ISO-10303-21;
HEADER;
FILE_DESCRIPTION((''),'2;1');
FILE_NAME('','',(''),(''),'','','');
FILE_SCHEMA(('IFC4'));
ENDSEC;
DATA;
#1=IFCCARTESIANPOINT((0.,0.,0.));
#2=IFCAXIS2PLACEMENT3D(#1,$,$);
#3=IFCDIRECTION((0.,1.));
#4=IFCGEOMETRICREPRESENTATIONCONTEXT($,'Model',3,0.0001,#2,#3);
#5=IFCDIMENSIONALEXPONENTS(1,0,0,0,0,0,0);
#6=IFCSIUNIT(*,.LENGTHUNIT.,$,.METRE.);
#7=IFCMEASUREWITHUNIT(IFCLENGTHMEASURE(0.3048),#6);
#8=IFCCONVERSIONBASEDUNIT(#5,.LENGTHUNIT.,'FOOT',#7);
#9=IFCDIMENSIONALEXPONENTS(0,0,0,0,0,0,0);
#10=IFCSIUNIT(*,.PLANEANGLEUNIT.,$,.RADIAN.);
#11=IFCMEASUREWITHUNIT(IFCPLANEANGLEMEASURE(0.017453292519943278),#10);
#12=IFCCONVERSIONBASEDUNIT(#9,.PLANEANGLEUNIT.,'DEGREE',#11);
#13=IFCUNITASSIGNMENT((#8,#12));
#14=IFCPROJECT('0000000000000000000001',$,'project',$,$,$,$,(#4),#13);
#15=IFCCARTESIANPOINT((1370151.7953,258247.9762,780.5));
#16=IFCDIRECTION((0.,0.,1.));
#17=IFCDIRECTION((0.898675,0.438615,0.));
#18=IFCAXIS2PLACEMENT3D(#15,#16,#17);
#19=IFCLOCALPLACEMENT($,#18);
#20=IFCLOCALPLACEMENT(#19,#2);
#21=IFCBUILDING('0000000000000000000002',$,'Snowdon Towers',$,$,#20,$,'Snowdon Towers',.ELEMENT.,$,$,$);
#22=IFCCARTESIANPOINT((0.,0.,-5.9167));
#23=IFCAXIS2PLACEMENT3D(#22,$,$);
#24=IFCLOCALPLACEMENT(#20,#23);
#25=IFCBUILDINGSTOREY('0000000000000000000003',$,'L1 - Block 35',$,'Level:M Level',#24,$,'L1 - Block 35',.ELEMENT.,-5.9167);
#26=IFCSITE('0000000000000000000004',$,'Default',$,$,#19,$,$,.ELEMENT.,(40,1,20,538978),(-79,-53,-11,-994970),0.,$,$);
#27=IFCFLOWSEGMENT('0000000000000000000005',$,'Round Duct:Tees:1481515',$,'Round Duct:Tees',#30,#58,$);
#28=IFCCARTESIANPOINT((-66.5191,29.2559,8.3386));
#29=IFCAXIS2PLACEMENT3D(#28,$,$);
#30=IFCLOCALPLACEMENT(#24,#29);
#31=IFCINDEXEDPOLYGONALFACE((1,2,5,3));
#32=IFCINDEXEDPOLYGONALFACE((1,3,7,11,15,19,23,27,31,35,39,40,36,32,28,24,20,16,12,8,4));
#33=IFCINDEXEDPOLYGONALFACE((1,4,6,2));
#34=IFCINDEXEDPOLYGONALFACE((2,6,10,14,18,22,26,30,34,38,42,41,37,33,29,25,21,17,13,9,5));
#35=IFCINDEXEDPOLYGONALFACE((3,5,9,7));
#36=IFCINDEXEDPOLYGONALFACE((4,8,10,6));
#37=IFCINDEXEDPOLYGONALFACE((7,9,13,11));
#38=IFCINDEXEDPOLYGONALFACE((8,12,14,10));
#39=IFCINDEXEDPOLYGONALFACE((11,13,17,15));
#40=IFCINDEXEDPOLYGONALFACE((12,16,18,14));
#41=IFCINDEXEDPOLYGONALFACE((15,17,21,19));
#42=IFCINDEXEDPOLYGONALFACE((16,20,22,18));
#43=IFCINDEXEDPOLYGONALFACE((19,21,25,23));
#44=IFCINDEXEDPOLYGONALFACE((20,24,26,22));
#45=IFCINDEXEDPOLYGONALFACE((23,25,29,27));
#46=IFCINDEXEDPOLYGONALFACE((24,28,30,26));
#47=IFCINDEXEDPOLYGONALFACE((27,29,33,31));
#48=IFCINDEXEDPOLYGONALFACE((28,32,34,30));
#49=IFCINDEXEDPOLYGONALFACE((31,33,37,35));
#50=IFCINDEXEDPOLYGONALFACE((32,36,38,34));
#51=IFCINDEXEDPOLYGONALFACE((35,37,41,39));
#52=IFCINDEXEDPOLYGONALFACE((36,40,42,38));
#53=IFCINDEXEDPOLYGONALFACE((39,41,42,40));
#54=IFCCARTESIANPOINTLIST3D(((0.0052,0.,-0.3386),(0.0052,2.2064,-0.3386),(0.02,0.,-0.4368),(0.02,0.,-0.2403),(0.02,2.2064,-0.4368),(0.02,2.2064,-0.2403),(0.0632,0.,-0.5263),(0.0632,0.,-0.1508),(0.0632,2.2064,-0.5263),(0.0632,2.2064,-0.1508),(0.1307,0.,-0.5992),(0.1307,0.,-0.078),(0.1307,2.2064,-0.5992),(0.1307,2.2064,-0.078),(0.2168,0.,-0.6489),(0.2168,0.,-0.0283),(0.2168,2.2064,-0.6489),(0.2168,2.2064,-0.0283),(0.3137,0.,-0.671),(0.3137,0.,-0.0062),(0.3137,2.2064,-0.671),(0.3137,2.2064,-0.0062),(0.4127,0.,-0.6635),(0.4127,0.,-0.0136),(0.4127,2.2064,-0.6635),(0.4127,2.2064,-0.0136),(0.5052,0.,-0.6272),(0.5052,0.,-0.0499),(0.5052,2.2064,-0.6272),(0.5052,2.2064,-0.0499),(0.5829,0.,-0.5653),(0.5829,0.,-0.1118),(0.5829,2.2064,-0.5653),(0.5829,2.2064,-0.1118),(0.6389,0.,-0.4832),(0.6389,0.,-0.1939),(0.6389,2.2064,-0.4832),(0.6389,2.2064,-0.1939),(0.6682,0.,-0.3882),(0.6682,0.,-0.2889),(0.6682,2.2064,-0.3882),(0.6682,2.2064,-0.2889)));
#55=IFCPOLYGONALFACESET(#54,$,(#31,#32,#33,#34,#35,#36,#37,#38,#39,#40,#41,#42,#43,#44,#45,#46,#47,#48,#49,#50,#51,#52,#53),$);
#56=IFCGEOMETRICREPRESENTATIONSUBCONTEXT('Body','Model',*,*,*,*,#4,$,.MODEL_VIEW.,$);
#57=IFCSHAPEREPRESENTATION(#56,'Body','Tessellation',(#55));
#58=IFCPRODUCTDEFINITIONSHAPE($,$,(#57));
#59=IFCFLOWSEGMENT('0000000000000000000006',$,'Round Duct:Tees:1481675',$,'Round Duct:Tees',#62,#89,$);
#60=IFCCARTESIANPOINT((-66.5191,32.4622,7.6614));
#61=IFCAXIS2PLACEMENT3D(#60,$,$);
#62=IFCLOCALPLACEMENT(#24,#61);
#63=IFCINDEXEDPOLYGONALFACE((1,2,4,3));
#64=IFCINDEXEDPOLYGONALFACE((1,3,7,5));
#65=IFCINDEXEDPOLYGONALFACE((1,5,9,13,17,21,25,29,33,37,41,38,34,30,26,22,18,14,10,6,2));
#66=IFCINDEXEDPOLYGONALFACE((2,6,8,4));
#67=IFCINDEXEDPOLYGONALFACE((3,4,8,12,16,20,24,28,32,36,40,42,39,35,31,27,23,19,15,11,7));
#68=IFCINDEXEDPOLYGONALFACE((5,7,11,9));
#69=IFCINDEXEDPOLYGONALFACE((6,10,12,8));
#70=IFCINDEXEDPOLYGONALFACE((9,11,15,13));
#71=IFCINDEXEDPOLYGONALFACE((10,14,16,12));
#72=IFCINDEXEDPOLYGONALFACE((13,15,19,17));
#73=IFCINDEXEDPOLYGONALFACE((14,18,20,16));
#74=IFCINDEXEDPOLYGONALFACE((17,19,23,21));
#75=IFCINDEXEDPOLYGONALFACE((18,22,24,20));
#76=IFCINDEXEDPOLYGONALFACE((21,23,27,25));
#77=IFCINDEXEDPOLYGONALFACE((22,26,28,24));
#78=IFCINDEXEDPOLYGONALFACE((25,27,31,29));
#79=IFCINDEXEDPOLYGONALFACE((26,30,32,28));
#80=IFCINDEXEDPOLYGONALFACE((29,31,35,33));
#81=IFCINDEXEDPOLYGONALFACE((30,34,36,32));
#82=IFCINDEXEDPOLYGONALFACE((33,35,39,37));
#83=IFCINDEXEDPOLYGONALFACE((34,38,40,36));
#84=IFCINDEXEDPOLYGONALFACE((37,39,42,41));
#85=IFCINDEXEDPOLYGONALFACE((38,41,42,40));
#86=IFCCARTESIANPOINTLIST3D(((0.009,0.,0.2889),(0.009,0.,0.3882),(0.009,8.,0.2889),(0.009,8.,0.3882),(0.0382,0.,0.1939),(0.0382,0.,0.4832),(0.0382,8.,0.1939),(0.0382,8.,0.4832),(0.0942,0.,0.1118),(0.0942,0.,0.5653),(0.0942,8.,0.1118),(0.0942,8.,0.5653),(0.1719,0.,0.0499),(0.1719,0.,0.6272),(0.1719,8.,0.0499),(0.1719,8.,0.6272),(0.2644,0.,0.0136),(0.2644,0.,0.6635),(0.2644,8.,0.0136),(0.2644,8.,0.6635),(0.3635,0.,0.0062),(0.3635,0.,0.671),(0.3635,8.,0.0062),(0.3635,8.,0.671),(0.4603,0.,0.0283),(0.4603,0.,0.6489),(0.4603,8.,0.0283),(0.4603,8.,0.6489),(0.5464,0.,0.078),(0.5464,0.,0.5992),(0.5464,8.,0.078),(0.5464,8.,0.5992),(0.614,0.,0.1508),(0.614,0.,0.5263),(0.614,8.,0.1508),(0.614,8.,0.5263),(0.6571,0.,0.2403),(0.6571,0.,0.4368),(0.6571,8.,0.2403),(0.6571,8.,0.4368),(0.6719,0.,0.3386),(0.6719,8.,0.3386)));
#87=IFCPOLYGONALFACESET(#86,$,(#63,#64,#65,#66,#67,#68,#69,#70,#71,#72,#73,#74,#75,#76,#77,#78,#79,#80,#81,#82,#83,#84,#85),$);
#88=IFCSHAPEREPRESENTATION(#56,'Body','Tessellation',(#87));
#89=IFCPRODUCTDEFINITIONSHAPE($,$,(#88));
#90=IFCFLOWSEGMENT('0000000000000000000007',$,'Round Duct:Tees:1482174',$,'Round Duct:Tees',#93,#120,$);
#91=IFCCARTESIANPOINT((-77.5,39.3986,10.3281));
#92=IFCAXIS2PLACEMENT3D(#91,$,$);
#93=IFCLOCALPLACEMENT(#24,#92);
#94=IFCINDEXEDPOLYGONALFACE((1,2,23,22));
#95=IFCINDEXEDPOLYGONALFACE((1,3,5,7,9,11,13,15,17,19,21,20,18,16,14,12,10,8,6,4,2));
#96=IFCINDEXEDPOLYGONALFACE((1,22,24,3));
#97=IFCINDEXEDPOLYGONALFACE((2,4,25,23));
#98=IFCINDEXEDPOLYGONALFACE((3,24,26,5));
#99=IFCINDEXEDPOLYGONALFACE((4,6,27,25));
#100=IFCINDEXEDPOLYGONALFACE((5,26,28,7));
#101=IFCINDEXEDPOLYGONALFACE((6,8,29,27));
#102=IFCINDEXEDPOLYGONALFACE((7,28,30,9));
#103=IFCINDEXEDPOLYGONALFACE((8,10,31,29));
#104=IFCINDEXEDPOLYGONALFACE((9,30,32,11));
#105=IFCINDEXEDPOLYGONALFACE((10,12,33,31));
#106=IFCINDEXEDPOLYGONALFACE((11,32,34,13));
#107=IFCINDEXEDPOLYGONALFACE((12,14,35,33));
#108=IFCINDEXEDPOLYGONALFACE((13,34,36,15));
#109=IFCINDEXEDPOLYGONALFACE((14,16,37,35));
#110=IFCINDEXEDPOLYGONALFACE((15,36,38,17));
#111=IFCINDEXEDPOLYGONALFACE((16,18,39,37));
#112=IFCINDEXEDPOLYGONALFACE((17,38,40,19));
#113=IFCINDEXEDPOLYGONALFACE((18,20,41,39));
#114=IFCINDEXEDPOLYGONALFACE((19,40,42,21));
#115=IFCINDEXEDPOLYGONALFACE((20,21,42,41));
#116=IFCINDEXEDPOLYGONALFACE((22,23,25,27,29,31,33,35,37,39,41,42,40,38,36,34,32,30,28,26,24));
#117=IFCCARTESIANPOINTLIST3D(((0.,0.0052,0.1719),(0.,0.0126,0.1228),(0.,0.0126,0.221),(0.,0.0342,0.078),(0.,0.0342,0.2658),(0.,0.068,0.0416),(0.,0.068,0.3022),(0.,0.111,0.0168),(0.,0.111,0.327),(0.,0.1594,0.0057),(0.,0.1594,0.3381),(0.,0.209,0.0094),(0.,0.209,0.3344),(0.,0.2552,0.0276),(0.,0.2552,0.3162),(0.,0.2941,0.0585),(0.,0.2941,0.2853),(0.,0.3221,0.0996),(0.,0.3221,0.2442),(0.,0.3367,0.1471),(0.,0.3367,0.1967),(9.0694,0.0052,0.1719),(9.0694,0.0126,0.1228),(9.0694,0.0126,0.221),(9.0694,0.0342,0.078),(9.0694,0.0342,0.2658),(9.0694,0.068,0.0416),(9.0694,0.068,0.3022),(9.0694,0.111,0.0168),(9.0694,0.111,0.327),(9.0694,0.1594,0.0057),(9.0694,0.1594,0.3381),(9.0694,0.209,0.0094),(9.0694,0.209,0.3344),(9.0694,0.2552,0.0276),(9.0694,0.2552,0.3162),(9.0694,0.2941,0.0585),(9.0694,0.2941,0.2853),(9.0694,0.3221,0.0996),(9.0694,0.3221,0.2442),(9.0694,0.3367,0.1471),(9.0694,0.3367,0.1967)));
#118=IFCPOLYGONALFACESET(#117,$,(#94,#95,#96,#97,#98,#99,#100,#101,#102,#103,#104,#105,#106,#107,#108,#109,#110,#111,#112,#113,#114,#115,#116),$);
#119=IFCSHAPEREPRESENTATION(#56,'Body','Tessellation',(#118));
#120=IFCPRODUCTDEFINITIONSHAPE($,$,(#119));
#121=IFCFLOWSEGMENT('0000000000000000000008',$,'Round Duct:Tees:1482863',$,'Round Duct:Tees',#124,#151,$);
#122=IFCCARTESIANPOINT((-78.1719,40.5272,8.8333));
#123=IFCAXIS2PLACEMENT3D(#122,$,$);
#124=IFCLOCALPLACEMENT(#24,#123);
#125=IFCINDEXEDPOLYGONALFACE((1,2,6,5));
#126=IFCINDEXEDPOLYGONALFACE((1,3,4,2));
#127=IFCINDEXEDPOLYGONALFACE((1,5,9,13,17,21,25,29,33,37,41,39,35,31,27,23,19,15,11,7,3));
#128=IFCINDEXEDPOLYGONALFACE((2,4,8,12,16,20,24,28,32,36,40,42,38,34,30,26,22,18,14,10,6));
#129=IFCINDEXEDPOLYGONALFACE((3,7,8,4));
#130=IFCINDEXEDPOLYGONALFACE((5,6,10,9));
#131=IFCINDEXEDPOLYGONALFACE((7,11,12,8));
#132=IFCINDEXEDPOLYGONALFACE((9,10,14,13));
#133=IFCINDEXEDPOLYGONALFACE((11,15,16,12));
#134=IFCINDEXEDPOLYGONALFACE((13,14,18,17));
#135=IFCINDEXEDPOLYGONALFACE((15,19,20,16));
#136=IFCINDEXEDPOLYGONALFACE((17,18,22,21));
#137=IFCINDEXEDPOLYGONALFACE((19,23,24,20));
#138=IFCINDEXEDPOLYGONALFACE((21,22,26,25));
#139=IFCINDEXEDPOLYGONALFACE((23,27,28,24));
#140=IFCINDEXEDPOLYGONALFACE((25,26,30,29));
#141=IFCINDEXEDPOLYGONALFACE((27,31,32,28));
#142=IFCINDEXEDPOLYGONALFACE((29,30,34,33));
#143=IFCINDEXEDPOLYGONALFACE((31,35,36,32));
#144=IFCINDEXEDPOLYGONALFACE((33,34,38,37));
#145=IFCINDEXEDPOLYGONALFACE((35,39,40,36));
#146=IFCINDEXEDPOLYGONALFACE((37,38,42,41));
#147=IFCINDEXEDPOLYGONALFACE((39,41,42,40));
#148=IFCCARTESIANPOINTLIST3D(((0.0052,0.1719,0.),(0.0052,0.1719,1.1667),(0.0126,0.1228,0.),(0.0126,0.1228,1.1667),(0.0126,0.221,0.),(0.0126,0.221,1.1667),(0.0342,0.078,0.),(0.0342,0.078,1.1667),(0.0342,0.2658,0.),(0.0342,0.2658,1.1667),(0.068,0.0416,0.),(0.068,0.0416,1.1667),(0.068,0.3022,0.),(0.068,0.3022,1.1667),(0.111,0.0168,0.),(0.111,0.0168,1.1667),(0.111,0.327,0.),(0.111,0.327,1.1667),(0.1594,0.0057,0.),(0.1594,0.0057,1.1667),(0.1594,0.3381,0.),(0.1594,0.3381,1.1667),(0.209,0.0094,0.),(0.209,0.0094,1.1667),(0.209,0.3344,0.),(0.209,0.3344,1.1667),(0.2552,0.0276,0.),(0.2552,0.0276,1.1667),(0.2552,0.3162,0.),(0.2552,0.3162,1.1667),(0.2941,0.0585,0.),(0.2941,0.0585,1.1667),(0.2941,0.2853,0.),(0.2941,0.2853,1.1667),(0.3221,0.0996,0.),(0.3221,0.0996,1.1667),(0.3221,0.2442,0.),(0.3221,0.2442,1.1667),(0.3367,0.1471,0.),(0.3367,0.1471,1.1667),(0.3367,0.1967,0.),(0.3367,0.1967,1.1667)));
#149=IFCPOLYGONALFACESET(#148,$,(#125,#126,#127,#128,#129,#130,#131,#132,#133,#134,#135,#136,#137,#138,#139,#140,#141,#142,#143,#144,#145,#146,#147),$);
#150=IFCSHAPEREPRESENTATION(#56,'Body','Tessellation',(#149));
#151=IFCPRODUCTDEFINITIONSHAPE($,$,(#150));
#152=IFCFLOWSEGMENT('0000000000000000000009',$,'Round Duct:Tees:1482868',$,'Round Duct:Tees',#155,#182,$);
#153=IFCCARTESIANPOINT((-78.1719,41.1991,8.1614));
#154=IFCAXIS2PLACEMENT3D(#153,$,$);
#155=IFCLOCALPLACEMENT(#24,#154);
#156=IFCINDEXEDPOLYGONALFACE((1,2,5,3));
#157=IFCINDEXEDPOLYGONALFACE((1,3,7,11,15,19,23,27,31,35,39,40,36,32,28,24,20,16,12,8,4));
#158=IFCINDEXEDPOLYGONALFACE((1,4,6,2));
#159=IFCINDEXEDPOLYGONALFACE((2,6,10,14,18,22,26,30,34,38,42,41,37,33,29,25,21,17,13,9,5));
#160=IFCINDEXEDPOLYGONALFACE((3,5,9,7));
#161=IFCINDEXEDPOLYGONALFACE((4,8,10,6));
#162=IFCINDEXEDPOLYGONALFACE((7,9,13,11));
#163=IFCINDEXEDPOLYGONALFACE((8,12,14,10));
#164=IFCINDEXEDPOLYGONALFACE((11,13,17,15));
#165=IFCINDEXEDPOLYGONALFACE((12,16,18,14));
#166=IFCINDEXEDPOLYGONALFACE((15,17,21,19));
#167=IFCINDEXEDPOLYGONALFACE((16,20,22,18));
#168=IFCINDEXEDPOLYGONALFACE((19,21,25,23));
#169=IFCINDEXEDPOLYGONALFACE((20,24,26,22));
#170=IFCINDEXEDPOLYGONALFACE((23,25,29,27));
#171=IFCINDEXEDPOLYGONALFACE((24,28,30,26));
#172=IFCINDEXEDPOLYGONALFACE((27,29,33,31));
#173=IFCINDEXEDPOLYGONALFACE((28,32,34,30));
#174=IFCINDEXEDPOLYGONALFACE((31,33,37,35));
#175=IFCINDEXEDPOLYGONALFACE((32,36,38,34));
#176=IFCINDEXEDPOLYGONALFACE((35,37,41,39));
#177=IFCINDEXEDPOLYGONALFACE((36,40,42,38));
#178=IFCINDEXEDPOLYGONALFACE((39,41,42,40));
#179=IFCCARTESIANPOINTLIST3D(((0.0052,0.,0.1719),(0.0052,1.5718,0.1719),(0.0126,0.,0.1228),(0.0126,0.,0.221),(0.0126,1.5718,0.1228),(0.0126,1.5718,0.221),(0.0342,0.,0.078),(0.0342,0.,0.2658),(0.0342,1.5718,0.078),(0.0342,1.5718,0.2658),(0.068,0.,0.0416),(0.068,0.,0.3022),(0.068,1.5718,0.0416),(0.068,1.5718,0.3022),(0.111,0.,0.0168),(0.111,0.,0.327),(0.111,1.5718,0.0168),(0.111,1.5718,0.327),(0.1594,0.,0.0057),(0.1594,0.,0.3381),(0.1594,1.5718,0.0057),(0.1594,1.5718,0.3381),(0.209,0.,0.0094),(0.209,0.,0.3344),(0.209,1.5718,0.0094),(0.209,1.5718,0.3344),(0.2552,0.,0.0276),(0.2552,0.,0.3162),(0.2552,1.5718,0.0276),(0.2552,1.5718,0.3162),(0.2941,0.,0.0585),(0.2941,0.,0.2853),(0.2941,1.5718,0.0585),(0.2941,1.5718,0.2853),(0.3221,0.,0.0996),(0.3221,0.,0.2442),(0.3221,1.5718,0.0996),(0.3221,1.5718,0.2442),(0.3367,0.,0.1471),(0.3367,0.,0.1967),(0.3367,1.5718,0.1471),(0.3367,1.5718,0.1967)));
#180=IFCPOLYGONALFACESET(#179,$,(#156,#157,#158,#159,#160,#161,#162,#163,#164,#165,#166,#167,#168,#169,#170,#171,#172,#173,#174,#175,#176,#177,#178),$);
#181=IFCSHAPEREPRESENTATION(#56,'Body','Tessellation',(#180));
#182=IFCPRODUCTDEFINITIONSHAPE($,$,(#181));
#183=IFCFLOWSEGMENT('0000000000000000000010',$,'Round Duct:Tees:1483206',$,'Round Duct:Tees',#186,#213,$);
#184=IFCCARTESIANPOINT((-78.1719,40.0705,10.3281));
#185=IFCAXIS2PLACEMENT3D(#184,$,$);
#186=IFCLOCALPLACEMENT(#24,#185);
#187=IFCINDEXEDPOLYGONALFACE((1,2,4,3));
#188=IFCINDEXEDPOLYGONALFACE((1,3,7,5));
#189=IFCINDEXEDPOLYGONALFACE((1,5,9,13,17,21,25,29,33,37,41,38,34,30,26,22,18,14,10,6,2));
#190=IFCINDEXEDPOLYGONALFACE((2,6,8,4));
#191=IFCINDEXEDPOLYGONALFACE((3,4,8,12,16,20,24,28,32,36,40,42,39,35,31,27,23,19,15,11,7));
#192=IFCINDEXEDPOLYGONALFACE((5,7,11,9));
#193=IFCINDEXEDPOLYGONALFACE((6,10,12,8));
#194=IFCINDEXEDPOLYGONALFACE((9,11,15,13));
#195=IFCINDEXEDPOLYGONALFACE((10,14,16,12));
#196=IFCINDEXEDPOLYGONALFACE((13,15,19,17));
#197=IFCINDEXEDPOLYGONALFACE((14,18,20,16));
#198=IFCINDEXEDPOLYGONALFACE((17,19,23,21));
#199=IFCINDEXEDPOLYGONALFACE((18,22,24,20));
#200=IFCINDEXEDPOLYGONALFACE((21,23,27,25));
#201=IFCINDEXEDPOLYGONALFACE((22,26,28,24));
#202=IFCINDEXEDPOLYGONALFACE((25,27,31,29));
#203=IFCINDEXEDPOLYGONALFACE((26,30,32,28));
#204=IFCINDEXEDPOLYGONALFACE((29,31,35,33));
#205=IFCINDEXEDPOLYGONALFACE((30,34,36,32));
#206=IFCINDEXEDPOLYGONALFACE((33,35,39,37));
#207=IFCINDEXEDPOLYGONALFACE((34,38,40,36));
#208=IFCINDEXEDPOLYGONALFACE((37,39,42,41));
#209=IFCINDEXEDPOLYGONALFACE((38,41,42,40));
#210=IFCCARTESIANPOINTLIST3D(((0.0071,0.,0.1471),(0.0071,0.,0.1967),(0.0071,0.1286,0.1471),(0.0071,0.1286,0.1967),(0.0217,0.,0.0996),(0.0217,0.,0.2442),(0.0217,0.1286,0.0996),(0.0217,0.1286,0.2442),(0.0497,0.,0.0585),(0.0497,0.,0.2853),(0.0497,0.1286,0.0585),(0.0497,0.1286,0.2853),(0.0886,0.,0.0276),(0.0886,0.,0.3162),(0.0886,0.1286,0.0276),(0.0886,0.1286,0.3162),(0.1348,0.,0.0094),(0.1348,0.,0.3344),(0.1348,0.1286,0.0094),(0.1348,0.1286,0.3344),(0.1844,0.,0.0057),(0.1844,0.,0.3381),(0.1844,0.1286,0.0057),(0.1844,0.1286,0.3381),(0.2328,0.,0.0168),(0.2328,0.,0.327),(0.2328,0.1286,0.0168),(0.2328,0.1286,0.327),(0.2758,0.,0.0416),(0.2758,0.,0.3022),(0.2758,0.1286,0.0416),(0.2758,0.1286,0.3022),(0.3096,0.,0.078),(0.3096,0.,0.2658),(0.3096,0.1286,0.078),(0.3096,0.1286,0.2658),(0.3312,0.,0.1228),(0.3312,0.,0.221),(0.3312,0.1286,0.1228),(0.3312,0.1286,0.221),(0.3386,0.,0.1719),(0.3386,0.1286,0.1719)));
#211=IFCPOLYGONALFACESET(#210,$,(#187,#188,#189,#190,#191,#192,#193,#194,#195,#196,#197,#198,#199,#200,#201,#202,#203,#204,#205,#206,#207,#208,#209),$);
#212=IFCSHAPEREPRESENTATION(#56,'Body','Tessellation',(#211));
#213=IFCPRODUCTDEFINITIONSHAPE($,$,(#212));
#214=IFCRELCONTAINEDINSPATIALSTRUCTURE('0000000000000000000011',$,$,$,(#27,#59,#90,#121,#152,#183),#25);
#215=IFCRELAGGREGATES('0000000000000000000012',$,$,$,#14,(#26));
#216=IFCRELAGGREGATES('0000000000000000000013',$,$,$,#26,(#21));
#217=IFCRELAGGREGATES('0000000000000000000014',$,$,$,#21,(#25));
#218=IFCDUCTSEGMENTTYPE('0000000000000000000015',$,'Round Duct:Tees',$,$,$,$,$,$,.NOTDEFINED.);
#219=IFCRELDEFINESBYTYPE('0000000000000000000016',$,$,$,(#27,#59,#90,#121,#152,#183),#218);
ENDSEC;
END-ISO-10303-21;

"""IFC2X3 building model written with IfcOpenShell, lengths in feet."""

from ifc_helpers import new_model, entity, si_unit, converted_unit, direction, frame, frame_2d, origin, origin_2d_with_axis, place, context, subcontext, project, spatial, circle, extrude, type_object, element, save


model = new_model("IFC2X3")

# Units and contexts
model_context = context("Model", 3, precision=0.0001, world=origin(), true_north=direction((0.0, 1.0)))
body_context = subcontext(model_context, "Body", "Model", "MODEL_VIEW")
ifc_project = project(units=[converted_unit("LENGTHUNIT", "FOOT", entity("IfcLengthMeasure", 0.3048), si_unit("LENGTHUNIT", "METRE"), dimensions=[1, 0, 0, 0, 0, 0, 0]), converted_unit("PLANEANGLEUNIT", "DEGREE", entity("IfcPlaneAngleMeasure", 0.017453292519943278), si_unit("PLANEANGLEUNIT", "RADIAN"), dimensions=[0, 0, 0, 0, 0, 0, 0])], contexts=[model_context])

# Site, building, storey
site_placement = place(None, frame((1370151.7953, 258247.9762, 780.5), z_axis=(0.0, 0.0, 1.0), x_axis=(0.898675, 0.438615, 0.0)))
site = spatial("IfcSite", under=ifc_project, at=site_placement, Name="Default", CompositionType="ELEMENT", RefLatitude=(40, 1, 20, 538978), RefLongitude=(-79, -53, -11, -994970), RefElevation=0.0)
building_placement = place(site_placement, origin())
building = spatial("IfcBuilding", under=site, at=building_placement, Name="Snowdon Towers", LongName="Snowdon Towers", CompositionType="ELEMENT")
storey_placement = place(building_placement, frame((0.0, 0.0, -5.9167)))
storey = spatial("IfcBuildingStorey", under=building, at=storey_placement, Name="L1 - Block 35", ObjectType="Level:M Level", LongName="L1 - Block 35", CompositionType="ELEMENT", Elevation=-5.9167)

# Flow segments
duct_segment_type = type_object("IfcDuctSegmentType", Name="Round Duct:Tees", PredefinedType="NOTDEFINED")
flow_segment_1_placement = place(storey_placement, frame((-66.5191, 29.2559, 8.3386)))
element("IfcFlowSegment", 1, at=flow_segment_1_placement, inside=storey, type_object=duct_segment_type, Name="Round Duct:Tees:1481515", ObjectType="Round Duct:Tees", context=body_context, shape_type="SweptSolid", body=[
    extrude(circle(Radius=0.3333, at=frame_2d((0.0, 0.0), x_axis=(1.0, 0.0))), frame((0.3386, 0.0, -0.3386), z_axis=(0.0, 1.0, 0.0), x_axis=(-1.0, 0.0, 0.0)), (0.0, 0.0, 1.0), 2.2064),
])
flow_segment_2_placement = place(storey_placement, frame((-66.5191, 32.4622, 7.6614)))
element("IfcFlowSegment", 2, at=flow_segment_2_placement, inside=storey, type_object=duct_segment_type, Name="Round Duct:Tees:1481675", ObjectType="Round Duct:Tees", context=body_context, shape_type="SweptSolid", body=[
    extrude(circle(Radius=0.3333, at=frame_2d((0.0, 0.0), x_axis=(1.0, 0.0))), frame((0.3386, 0.0, 0.3386), z_axis=(0.0, 1.0, 0.0), x_axis=(1.0, 0.0, 0.0)), (0.0, 0.0, 1.0), 8.0),
])
flow_segment_3_placement = place(storey_placement, frame((-77.5, 39.3986, 10.3281)))
element("IfcFlowSegment", 3, at=flow_segment_3_placement, inside=storey, type_object=duct_segment_type, Name="Round Duct:Tees:1482174", ObjectType="Round Duct:Tees", context=body_context, shape_type="SweptSolid", body=[
    extrude(circle(Radius=0.1667, at=origin_2d_with_axis()), frame((0.0, 0.1719, 0.1719), z_axis=(1.0, 0.0, 0.0), x_axis=(0.0, -1.0, 0.0)), (0.0, 0.0, 1.0), 9.0694),
])
flow_segment_4_placement = place(storey_placement, frame((-78.1719, 40.5272, 8.8333)))
element("IfcFlowSegment", 4, at=flow_segment_4_placement, inside=storey, type_object=duct_segment_type, Name="Round Duct:Tees:1482863", ObjectType="Round Duct:Tees", context=body_context, shape_type="SweptSolid", body=[
    extrude(circle(Radius=0.1667, at=frame_2d((0.0, 0.0), x_axis=(1.0, 0.0))), frame((0.1719, 0.1719, 0.0), z_axis=(0.0, 0.0, 1.0), x_axis=(-1.0, 0.0, 0.0)), (0.0, 0.0, 1.0), 1.1667),
])
flow_segment_5_placement = place(storey_placement, frame((-78.1719, 41.1991, 8.1614)))
element("IfcFlowSegment", 5, at=flow_segment_5_placement, inside=storey, type_object=duct_segment_type, Name="Round Duct:Tees:1482868", ObjectType="Round Duct:Tees", context=body_context, shape_type="SweptSolid", body=[
    extrude(circle(Radius=0.1667, at=frame_2d((0.0, 0.0), x_axis=(1.0, 0.0))), frame((0.1719, 0.0, 0.1719), z_axis=(0.0, 1.0, 0.0), x_axis=(-1.0, 0.0, 0.0)), (0.0, 0.0, 1.0), 1.5718),
])
flow_segment_6_placement = place(storey_placement, frame((-78.1719, 40.0705, 10.3281)))
element("IfcFlowSegment", 6, at=flow_segment_6_placement, inside=storey, type_object=duct_segment_type, Name="Round Duct:Tees:1483206", ObjectType="Round Duct:Tees", context=body_context, shape_type="SweptSolid", body=[
    extrude(circle(Radius=0.1667, at=origin_2d_with_axis()), frame((0.1719, 0.0, 0.1719), z_axis=(0.0, 1.0, 0.0), x_axis=(1.0, 0.0, 0.0)), (0.0, 0.0, 1.0), 0.1286),
])

save(model, "model.ifc")
